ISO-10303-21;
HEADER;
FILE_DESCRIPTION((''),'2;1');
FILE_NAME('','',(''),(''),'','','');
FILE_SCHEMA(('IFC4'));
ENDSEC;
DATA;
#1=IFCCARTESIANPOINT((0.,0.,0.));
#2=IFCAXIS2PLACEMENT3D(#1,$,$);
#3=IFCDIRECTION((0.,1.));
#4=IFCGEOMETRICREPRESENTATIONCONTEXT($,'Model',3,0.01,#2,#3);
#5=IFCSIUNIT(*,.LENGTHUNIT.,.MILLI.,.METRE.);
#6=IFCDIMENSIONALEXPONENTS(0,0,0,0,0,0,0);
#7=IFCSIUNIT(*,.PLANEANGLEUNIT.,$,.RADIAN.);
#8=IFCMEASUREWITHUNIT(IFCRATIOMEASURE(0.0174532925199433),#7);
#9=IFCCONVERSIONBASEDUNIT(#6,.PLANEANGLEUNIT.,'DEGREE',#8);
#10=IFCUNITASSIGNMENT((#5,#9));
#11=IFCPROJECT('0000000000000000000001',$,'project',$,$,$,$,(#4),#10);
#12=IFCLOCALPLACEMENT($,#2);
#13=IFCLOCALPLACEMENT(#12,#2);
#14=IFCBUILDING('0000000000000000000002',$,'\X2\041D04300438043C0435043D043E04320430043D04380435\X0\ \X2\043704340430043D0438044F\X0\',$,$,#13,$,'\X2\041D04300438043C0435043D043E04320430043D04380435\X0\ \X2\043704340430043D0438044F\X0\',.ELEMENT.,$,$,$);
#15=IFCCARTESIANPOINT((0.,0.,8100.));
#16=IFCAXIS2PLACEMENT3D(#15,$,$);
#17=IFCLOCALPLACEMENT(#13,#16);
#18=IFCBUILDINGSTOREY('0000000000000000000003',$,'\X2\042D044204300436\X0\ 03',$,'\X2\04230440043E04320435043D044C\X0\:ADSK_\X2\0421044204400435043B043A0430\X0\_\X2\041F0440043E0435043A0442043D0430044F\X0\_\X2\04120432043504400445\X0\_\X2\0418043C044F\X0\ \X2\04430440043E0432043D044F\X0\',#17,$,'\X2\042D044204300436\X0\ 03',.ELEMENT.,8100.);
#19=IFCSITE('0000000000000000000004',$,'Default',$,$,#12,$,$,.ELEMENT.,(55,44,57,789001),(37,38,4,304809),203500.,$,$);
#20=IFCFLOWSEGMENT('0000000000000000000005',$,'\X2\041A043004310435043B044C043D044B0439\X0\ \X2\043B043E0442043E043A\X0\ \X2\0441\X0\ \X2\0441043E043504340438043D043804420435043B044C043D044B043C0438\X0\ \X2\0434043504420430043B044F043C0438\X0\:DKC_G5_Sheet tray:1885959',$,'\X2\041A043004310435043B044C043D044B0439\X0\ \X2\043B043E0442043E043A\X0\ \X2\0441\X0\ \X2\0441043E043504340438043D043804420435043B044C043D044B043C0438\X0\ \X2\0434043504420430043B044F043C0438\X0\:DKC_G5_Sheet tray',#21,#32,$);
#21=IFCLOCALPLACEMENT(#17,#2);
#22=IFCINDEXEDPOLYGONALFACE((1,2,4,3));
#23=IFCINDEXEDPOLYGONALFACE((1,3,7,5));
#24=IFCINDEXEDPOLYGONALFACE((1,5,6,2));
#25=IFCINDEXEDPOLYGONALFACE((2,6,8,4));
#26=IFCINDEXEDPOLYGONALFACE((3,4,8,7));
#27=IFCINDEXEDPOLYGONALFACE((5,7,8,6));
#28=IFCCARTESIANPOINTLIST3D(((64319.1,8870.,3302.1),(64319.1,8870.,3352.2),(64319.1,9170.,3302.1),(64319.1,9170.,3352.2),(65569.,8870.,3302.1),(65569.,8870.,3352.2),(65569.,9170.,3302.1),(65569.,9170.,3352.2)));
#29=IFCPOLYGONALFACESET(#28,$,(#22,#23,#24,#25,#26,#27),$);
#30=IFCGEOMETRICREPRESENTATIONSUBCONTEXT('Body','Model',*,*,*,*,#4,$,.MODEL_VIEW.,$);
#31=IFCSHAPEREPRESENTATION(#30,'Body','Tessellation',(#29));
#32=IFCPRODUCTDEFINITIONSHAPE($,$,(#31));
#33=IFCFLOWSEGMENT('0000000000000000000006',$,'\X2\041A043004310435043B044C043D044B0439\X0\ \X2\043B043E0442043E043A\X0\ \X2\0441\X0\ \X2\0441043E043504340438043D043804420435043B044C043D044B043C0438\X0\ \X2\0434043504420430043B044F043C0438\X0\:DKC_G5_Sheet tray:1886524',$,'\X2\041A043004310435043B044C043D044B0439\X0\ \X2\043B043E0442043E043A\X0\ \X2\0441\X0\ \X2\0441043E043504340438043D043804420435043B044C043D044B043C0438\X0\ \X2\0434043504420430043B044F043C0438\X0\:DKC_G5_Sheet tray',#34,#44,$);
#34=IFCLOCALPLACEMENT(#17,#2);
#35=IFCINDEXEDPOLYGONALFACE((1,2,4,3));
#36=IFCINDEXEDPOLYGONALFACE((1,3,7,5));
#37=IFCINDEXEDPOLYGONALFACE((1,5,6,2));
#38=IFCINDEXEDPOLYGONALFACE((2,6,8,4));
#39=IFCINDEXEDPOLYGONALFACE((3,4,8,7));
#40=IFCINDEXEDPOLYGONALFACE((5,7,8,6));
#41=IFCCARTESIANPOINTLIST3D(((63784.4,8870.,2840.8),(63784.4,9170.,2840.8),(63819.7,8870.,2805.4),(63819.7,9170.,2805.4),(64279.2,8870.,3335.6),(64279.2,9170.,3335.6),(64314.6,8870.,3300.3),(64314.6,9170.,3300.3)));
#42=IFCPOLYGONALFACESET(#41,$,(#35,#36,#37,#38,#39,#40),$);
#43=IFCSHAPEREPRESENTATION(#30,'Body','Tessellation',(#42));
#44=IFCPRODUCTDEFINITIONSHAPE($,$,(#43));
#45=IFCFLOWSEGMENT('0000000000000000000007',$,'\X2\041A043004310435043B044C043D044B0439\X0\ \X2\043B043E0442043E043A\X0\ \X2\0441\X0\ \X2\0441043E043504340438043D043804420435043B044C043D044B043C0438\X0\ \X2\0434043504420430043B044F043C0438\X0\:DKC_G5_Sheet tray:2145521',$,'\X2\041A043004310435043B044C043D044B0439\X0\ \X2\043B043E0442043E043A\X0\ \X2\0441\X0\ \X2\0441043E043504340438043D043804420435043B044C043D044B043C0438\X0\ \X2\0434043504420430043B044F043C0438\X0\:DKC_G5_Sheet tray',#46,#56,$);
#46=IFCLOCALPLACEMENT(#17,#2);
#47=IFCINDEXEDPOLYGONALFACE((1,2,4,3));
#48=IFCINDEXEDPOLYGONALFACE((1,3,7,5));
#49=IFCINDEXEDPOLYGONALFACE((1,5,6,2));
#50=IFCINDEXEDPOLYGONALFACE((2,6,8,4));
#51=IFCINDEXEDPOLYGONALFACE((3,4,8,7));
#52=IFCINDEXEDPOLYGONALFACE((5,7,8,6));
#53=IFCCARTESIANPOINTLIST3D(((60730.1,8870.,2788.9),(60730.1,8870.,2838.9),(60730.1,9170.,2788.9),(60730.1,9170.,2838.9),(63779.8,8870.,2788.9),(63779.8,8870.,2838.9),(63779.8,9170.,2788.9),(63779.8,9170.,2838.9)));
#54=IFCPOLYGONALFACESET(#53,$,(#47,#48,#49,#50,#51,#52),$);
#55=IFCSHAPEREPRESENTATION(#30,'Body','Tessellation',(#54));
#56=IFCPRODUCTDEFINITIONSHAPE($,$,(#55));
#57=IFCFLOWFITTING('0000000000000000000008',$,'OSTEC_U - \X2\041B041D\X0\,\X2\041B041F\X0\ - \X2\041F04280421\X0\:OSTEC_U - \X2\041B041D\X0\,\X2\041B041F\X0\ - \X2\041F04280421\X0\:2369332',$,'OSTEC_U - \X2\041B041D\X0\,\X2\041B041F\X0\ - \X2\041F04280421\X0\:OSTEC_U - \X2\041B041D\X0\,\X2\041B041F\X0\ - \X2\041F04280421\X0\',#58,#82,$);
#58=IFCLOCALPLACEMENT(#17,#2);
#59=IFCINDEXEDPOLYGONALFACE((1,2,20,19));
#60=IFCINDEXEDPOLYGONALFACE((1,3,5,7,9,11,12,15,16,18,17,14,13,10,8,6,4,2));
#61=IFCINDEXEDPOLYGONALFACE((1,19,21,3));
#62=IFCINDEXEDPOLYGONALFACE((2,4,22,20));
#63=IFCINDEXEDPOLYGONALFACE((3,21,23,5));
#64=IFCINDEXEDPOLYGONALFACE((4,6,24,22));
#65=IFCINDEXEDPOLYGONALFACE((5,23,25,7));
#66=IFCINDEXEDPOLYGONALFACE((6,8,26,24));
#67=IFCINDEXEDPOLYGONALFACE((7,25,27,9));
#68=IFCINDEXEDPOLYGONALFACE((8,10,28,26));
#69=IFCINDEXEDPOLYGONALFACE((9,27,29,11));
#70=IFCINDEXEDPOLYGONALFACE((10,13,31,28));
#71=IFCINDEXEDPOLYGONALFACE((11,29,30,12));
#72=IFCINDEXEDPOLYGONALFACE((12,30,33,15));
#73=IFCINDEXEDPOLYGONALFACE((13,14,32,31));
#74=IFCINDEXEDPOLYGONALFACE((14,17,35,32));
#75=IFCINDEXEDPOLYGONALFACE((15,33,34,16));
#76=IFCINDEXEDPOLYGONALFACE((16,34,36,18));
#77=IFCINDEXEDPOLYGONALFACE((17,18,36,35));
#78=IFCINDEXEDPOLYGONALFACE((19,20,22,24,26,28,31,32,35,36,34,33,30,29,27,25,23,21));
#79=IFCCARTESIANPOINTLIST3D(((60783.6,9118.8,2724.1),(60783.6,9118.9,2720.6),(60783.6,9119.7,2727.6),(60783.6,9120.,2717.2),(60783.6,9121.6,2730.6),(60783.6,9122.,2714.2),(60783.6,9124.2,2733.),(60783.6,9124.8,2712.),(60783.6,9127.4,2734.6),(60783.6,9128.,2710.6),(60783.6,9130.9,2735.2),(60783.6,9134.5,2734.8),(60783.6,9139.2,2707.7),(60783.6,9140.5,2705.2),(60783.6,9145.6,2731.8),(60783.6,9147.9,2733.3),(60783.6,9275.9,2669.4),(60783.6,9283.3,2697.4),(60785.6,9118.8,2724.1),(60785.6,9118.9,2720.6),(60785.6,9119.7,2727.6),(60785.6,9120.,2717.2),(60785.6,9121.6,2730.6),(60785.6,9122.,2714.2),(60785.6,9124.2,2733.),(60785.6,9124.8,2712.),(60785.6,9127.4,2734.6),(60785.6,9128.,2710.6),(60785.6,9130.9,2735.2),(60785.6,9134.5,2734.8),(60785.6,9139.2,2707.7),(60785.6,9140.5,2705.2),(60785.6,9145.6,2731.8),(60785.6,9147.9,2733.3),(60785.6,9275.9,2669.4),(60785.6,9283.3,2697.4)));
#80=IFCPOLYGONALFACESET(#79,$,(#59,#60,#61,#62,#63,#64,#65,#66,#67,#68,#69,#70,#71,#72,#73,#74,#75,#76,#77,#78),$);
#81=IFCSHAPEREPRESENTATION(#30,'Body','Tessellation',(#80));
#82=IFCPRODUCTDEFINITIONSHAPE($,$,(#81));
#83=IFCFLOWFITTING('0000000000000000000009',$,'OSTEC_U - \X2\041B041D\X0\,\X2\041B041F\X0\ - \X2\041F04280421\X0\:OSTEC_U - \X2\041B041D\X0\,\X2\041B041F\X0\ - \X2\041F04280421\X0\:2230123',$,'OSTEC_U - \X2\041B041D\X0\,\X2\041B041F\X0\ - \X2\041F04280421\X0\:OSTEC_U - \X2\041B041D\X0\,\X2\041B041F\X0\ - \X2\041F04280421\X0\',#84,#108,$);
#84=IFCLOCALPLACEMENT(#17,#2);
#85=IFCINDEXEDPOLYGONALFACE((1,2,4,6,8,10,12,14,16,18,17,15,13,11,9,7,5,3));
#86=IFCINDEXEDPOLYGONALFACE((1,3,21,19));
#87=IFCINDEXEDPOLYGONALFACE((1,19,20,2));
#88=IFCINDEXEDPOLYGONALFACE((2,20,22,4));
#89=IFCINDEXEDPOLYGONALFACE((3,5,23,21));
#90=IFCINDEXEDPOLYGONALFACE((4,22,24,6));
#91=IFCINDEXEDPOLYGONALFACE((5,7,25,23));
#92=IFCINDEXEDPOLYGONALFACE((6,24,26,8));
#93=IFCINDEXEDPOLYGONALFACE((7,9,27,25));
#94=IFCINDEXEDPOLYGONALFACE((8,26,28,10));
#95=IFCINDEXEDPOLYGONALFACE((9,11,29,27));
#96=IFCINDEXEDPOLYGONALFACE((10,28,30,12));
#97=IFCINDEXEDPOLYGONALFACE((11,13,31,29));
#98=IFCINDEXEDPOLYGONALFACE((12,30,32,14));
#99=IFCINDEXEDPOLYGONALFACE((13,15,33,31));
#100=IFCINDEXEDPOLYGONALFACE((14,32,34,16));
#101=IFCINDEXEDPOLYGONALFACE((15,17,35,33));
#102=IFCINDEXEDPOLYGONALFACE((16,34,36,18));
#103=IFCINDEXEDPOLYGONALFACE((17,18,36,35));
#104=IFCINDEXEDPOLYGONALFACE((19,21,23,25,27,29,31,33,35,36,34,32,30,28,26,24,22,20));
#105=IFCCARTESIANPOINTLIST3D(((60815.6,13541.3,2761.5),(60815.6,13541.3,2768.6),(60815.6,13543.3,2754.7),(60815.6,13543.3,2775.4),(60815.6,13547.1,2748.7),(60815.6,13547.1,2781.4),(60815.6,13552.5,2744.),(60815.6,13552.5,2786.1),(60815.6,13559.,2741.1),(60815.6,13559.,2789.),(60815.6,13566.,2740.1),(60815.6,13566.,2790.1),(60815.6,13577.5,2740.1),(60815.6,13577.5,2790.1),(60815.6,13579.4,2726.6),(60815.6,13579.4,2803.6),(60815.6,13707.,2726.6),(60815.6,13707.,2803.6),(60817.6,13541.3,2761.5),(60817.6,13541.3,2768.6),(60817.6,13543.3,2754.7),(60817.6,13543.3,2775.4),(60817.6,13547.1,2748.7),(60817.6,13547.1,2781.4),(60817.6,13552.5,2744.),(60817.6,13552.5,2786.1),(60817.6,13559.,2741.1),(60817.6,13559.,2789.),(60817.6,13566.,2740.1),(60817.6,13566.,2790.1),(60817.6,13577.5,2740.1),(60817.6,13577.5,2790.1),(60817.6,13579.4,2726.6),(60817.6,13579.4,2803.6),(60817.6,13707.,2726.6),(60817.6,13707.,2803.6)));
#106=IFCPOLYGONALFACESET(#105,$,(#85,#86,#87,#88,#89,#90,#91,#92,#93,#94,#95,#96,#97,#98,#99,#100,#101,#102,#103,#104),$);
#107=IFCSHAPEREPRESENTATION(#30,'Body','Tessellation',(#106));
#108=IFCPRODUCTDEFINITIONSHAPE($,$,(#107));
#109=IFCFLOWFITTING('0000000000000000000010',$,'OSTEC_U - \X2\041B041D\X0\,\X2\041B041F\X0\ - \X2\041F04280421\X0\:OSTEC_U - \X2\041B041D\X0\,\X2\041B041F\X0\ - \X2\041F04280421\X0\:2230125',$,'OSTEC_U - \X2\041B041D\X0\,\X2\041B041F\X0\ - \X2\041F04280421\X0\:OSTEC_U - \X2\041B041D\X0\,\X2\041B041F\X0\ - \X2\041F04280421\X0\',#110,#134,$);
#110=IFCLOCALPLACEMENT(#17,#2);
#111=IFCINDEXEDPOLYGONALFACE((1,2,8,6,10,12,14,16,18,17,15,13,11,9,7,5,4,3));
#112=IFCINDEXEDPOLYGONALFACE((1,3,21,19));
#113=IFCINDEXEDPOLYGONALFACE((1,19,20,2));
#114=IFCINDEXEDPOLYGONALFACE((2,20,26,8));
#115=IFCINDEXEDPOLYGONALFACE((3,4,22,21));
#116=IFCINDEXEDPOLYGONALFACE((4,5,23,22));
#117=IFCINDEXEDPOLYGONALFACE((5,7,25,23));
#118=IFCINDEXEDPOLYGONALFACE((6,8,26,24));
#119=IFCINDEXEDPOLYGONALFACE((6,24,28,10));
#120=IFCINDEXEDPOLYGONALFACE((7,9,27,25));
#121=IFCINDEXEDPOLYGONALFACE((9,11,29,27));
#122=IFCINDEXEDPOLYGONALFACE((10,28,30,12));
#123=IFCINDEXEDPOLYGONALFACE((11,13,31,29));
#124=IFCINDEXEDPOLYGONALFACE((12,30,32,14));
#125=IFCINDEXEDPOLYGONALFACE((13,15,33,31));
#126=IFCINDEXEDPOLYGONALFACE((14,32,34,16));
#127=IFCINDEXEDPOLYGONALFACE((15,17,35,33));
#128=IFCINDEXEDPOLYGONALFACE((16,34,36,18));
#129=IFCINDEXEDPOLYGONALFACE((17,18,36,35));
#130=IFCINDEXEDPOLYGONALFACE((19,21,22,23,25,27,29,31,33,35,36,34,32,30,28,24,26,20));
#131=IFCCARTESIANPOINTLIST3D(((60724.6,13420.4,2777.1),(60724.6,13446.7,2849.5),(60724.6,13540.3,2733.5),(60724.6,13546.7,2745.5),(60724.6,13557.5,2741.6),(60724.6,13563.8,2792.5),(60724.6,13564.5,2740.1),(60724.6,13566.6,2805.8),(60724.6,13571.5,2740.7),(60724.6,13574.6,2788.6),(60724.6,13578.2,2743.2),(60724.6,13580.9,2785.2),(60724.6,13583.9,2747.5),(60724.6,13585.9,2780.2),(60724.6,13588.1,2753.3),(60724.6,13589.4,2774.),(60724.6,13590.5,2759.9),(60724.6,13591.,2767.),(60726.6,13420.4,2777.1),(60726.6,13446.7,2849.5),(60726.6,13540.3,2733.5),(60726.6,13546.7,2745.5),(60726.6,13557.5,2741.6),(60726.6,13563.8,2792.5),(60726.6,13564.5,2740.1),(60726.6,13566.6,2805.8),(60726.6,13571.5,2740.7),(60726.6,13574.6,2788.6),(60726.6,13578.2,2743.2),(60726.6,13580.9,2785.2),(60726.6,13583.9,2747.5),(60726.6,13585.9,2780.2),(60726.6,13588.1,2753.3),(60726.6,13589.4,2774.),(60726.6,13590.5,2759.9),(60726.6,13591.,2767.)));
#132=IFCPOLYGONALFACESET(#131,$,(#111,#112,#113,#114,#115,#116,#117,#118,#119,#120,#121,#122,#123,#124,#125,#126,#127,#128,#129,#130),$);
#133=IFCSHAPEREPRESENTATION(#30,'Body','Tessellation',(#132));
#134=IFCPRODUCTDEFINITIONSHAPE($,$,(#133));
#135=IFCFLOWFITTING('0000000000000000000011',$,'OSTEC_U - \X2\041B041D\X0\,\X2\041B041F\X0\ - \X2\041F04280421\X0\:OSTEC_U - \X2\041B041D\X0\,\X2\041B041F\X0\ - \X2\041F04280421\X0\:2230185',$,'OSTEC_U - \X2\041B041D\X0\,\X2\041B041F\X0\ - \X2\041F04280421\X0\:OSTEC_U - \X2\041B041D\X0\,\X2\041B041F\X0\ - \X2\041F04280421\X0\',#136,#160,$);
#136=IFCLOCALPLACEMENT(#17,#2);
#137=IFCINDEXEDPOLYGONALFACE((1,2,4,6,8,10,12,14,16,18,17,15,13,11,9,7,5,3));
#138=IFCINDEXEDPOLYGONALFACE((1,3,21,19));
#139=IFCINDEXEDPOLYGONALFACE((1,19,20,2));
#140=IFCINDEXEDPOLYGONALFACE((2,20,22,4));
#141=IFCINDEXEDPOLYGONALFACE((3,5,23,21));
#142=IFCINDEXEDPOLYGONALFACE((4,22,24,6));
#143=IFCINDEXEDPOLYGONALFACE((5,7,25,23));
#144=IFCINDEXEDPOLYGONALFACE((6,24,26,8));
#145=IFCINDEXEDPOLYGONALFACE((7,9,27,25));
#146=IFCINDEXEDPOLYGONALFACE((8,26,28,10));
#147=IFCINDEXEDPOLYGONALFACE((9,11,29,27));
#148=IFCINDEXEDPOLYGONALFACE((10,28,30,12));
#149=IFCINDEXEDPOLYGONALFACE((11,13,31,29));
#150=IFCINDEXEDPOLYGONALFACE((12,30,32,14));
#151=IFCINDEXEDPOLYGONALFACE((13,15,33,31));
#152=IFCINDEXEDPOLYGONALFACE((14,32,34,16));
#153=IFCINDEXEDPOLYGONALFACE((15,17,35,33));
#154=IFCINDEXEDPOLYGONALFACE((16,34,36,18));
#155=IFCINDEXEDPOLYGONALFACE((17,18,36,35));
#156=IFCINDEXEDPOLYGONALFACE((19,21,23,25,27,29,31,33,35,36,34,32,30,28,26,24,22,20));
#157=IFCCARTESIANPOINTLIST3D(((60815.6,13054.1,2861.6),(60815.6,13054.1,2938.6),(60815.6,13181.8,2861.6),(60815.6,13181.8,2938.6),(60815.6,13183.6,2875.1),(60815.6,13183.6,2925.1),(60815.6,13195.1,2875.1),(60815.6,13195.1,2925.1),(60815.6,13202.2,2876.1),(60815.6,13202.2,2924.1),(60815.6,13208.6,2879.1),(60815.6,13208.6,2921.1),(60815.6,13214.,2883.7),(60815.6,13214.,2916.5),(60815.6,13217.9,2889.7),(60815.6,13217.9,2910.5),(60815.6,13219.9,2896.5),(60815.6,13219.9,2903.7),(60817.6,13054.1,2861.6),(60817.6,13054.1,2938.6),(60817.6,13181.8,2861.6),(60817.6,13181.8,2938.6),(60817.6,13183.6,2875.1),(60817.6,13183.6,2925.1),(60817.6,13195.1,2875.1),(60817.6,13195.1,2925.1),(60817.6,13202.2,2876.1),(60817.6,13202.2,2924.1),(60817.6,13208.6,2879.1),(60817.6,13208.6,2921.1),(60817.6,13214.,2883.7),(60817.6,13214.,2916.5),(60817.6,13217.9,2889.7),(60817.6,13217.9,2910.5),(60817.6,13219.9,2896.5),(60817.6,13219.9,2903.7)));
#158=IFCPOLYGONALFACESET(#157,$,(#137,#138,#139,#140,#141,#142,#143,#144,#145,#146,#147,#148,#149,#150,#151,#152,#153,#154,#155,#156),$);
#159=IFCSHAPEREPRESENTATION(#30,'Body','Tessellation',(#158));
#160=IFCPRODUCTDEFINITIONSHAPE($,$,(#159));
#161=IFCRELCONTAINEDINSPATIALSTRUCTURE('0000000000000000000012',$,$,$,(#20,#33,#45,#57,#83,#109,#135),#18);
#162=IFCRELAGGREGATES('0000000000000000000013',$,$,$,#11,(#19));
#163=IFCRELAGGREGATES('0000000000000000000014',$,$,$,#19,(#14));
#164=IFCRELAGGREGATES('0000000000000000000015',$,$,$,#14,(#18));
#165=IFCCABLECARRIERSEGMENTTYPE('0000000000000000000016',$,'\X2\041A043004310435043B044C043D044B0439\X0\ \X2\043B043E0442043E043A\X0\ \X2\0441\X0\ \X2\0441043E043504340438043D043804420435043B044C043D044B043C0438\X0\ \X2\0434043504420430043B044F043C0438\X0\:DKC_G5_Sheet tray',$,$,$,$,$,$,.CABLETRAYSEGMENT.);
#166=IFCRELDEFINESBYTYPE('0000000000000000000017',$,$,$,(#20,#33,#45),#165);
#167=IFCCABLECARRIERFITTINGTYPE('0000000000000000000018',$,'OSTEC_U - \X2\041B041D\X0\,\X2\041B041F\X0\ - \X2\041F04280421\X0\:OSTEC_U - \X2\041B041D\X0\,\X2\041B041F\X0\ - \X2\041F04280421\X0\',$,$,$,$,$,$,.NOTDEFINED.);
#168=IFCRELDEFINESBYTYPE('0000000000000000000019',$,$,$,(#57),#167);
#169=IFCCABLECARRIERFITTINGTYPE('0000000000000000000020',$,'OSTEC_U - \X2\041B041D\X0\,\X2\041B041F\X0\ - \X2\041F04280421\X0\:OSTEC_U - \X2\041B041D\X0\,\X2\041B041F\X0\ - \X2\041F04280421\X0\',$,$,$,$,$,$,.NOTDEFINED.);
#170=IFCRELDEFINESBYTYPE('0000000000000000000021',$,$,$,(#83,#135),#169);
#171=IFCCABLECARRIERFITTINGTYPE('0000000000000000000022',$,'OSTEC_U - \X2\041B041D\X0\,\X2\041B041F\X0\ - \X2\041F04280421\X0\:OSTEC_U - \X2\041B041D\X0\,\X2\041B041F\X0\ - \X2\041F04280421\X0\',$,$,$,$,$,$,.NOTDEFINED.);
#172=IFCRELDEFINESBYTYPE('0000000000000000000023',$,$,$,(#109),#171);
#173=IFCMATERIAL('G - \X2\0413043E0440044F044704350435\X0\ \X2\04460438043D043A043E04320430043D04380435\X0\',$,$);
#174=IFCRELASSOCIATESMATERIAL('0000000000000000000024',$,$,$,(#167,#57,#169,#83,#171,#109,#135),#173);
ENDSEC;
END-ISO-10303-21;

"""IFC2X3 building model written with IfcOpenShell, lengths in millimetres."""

from ifc_helpers import new_model, entity, si_unit, converted_unit, direction, frame, frame_2d, origin, origin_2d_with_axis, place, context, subcontext, project, spatial, polyline, circle_curve, parameter, trimmed, segment, composite_curve, rectangle, outline, extrude, source, transform, mapped, material, type_object, type_shapes, element, save


model = new_model("IFC2X3")

# Units and contexts
model_context = context("Model", 3, precision=0.01, world=origin(), true_north=direction((0.0, 1.0)))
body_context = subcontext(model_context, "Body", "Model", "MODEL_VIEW")
ifc_project = project(units=[si_unit("LENGTHUNIT", "METRE", prefix="MILLI"), converted_unit("PLANEANGLEUNIT", "DEGREE", entity("IfcRatioMeasure", 0.0174532925199433), si_unit("PLANEANGLEUNIT", "RADIAN"), dimensions=[0, 0, 0, 0, 0, 0, 0])], contexts=[model_context])

# Site, building, storey
site_placement = place(None, origin())
site = spatial("IfcSite", under=ifc_project, at=site_placement, Name="Default", CompositionType="ELEMENT", RefLatitude=(55, 44, 57, 789001), RefLongitude=(37, 38, 4, 304809), RefElevation=203500.0)
building_placement = place(site_placement, origin())
building = spatial("IfcBuilding", under=site, at=building_placement, Name="Наименование здания", LongName="Наименование здания", CompositionType="ELEMENT")
storey_placement = place(building_placement, frame((0.0, 0.0, 8100.0)))
storey = spatial("IfcBuildingStorey", under=building, at=storey_placement, Name="Этаж 03", ObjectType="Уровень:ADSK_Стрелка_Проектная_Вверх_Имя уровня", LongName="Этаж 03", CompositionType="ELEMENT", Elevation=8100.0)

# Flow segments
cable_carrier_segment_type = type_object("IfcCableCarrierSegmentType", Name="Кабельный лоток с соединительными деталями:DKC_G5_Sheet tray", PredefinedType="CABLETRAYSEGMENT")
flow_segment_1_placement = place(storey_placement, frame((64319.1, 8870.0, 3302.2)))
element("IfcFlowSegment", 1, at=flow_segment_1_placement, inside=storey, type_object=cable_carrier_segment_type, Name="Кабельный лоток с соединительными деталями:DKC_G5_Sheet tray:1885959", ObjectType="Кабельный лоток с соединительными деталями:DKC_G5_Sheet tray", context=body_context, shape_type="SweptSolid", body=[
    extrude(rectangle(XDim=1249.9, YDim=300.0, at=origin_2d_with_axis()), frame((624.9, 150.0, 0.0), z_axis=(0.0, 0.0, 1.0), x_axis=(-1.0, 0.0, 0.0)), (0.0, 0.0, 1.0), 50.0),
])
flow_segment_2_placement = place(storey_placement, frame((63784.4, 8870.0, 2805.4)))
element("IfcFlowSegment", 2, at=flow_segment_2_placement, inside=storey, type_object=cable_carrier_segment_type, Name="Кабельный лоток с соединительными деталями:DKC_G5_Sheet tray:1886524", ObjectType="Кабельный лоток с соединительными деталями:DKC_G5_Sheet tray", context=body_context, shape_type="SweptSolid", body=[
    extrude(rectangle(XDim=50.0, YDim=300.0, at=origin_2d_with_axis()), frame((17.7, 150.0, 17.7), z_axis=(0.707107, 0.0, 0.707107), x_axis=(-0.707107, 0.0, 0.707107)), (0.0, 0.0, 1.0), 699.8),
])
flow_segment_3_placement = place(storey_placement, frame((60730.1, 8870.0, 2788.9)))
element("IfcFlowSegment", 3, at=flow_segment_3_placement, inside=storey, type_object=cable_carrier_segment_type, Name="Кабельный лоток с соединительными деталями:DKC_G5_Sheet tray:2145521", ObjectType="Кабельный лоток с соединительными деталями:DKC_G5_Sheet tray", context=body_context, shape_type="SweptSolid", body=[
    extrude(rectangle(XDim=3049.7, YDim=300.0, at=origin_2d_with_axis()), frame((1524.9, 150.0, 0.0)), (0.0, 0.0, 1.0), 50.0),
])

# Flow fittings
ifc_material_1 = material(Name="G - Горячее цинкование")
cable_carrier_fitting_type_1 = type_object("IfcCableCarrierFittingType", Name="OSTEC_U - ЛН,ЛП - ПШС:OSTEC_U - ЛН,ЛП - ПШС", PredefinedType="NOTDEFINED", material=ifc_material_1)
shared_shape_1 = source(origin(), body_context, "Body", "SweptSolid", [
    extrude(outline(composite_curve([segment(trimmed(circle_curve(frame_2d((-44.6, 0.0), x_axis=(1.0, 0.0)), 12.5), [parameter(90.0)], [parameter(270.0)], True, "PARAMETER"), True, "CONTINUOUS"), segment(polyline([(-44.6, -12.5), (-33.1, -12.5)]), True, "CONTINUOUS"), segment(polyline([(-33.1, -12.5), (-31.2, -14.5)]), True, "CONTINUOUS"), segment(polyline([(-31.2, -14.5), (108.9, -14.5)]), True, "CONTINUOUS"), segment(polyline([(108.9, -14.5), (108.9, 14.5)]), True, "CONTINUOUS"), segment(polyline([(108.9, 14.5), (-31.2, 14.5)]), True, "CONTINUOUS"), segment(polyline([(-31.2, 14.5), (-33.1, 12.5)]), True, "CONTINUOUS"), segment(polyline([(-33.1, 12.5), (-44.6, 12.5)]), True, "CONTINUOUS")], self_intersect=False)), frame((44.6, 0.0, 0.0)), (0.0, 0.0, 1.0), 2.0),
])
type_shapes(cable_carrier_fitting_type_1, [shared_shape_1])
for number, where, z_axis, x_axis, name in (
    (4, (60783.6, 9131.2, 2722.7), (1.0, 0.0, 0.0), (0.0, 0.966668, -0.256034), "OSTEC_U - ЛН,ЛП - ПШС:OSTEC_U - ЛН,ЛП - ПШС:2369332"),
):
    element("IfcFlowFitting", number, at=place(storey_placement, frame(where, z_axis=z_axis, x_axis=x_axis)), inside=storey, type_object=cable_carrier_fitting_type_1, material=ifc_material_1, Name=name, ObjectType="OSTEC_U - ЛН,ЛП - ПШС:OSTEC_U - ЛН,ЛП - ПШС", context=body_context, shape_type="MappedRepresentation", body=[
        mapped(shared_shape_1, transform((0.0, 0.0, 0.0), scale=1.0)),
    ])
cable_carrier_fitting_type_2 = type_object("IfcCableCarrierFittingType", Name="OSTEC_U - ЛН,ЛП - ПШС:OSTEC_U - ЛН,ЛП - ПШС", PredefinedType="NOTDEFINED", material=ifc_material_1)
shared_shape_2 = source(origin(), body_context, "Body", "SweptSolid", [
    extrude(outline(composite_curve([segment(trimmed(circle_curve(frame_2d((-41.5, 0.0), x_axis=(1.0, 0.0)), 25.0), [parameter(90.0)], [parameter(270.0)], True, "PARAMETER"), True, "CONTINUOUS"), segment(polyline([(-41.5, -25.0), (-30.0, -25.0)]), True, "CONTINUOUS"), segment(polyline([(-30.0, -25.0), (-28.1, -38.5)]), True, "CONTINUOUS"), segment(polyline([(-28.1, -38.5), (99.5, -38.5)]), True, "CONTINUOUS"), segment(polyline([(99.5, -38.5), (99.5, 38.5)]), True, "CONTINUOUS"), segment(polyline([(99.5, 38.5), (-28.1, 38.5)]), True, "CONTINUOUS"), segment(polyline([(-28.1, 38.5), (-30.0, 25.0)]), True, "CONTINUOUS"), segment(polyline([(-30.0, 25.0), (-41.5, 25.0)]), True, "CONTINUOUS")], self_intersect=False)), frame((41.5, 0.0, 0.0), z_axis=(0.0, 0.0, -1.0), x_axis=(1.0, 0.0, 0.0)), (0.0, 0.0, -1.0), 2.0),
])
type_shapes(cable_carrier_fitting_type_2, [shared_shape_2])
flow_fitting_1_placement = place(storey_placement, frame((60815.6, 13566.0, 2765.1), z_axis=(1.0, 0.0, 0.0), x_axis=(0.0, 1.0, 0.000034)))
element("IfcFlowFitting", 5, at=flow_fitting_1_placement, inside=storey, type_object=cable_carrier_fitting_type_2, material=ifc_material_1, Name="OSTEC_U - ЛН,ЛП - ПШС:OSTEC_U - ЛН,ЛП - ПШС:2230123", ObjectType="OSTEC_U - ЛН,ЛП - ПШС:OSTEC_U - ЛН,ЛП - ПШС", context=body_context, shape_type="MappedRepresentation", body=[
    mapped(shared_shape_2, transform((0.0, 0.0, 0.0), scale=1.0)),
])
cable_carrier_fitting_type_3 = type_object("IfcCableCarrierFittingType", Name="OSTEC_U - ЛН,ЛП - ПШС:OSTEC_U - ЛН,ЛП - ПШС", PredefinedType="NOTDEFINED", material=ifc_material_1)
type_shapes(cable_carrier_fitting_type_3, [shared_shape_2])
flow_fitting_2_placement = place(storey_placement, frame((60726.7, 13566.0, 2765.1), z_axis=(-1.0, 0.0, 0.0), x_axis=(0.0, -0.939662, 0.342104)))
element("IfcFlowFitting", 6, at=flow_fitting_2_placement, inside=storey, type_object=cable_carrier_fitting_type_3, material=ifc_material_1, Name="OSTEC_U - ЛН,ЛП - ПШС:OSTEC_U - ЛН,ЛП - ПШС:2230125", ObjectType="OSTEC_U - ЛН,ЛП - ПШС:OSTEC_U - ЛН,ЛП - ПШС", context=body_context, shape_type="MappedRepresentation", body=[
    mapped(shared_shape_2, transform((0.0, 0.0, 0.0), scale=1.0)),
])
flow_fitting_3_placement = place(storey_placement, frame((60815.6, 13195.1, 2900.1), z_axis=(1.0, 0.0, 0.0), x_axis=(0.0, -1.0, 0.0)))
element("IfcFlowFitting", 7, at=flow_fitting_3_placement, inside=storey, type_object=cable_carrier_fitting_type_2, material=ifc_material_1, Name="OSTEC_U - ЛН,ЛП - ПШС:OSTEC_U - ЛН,ЛП - ПШС:2230185", ObjectType="OSTEC_U - ЛН,ЛП - ПШС:OSTEC_U - ЛН,ЛП - ПШС", context=body_context, shape_type="MappedRepresentation", body=[
    mapped(shared_shape_2, transform((0.0, 0.0, 0.0), scale=1.0)),
])

save(model, "model.ifc")
